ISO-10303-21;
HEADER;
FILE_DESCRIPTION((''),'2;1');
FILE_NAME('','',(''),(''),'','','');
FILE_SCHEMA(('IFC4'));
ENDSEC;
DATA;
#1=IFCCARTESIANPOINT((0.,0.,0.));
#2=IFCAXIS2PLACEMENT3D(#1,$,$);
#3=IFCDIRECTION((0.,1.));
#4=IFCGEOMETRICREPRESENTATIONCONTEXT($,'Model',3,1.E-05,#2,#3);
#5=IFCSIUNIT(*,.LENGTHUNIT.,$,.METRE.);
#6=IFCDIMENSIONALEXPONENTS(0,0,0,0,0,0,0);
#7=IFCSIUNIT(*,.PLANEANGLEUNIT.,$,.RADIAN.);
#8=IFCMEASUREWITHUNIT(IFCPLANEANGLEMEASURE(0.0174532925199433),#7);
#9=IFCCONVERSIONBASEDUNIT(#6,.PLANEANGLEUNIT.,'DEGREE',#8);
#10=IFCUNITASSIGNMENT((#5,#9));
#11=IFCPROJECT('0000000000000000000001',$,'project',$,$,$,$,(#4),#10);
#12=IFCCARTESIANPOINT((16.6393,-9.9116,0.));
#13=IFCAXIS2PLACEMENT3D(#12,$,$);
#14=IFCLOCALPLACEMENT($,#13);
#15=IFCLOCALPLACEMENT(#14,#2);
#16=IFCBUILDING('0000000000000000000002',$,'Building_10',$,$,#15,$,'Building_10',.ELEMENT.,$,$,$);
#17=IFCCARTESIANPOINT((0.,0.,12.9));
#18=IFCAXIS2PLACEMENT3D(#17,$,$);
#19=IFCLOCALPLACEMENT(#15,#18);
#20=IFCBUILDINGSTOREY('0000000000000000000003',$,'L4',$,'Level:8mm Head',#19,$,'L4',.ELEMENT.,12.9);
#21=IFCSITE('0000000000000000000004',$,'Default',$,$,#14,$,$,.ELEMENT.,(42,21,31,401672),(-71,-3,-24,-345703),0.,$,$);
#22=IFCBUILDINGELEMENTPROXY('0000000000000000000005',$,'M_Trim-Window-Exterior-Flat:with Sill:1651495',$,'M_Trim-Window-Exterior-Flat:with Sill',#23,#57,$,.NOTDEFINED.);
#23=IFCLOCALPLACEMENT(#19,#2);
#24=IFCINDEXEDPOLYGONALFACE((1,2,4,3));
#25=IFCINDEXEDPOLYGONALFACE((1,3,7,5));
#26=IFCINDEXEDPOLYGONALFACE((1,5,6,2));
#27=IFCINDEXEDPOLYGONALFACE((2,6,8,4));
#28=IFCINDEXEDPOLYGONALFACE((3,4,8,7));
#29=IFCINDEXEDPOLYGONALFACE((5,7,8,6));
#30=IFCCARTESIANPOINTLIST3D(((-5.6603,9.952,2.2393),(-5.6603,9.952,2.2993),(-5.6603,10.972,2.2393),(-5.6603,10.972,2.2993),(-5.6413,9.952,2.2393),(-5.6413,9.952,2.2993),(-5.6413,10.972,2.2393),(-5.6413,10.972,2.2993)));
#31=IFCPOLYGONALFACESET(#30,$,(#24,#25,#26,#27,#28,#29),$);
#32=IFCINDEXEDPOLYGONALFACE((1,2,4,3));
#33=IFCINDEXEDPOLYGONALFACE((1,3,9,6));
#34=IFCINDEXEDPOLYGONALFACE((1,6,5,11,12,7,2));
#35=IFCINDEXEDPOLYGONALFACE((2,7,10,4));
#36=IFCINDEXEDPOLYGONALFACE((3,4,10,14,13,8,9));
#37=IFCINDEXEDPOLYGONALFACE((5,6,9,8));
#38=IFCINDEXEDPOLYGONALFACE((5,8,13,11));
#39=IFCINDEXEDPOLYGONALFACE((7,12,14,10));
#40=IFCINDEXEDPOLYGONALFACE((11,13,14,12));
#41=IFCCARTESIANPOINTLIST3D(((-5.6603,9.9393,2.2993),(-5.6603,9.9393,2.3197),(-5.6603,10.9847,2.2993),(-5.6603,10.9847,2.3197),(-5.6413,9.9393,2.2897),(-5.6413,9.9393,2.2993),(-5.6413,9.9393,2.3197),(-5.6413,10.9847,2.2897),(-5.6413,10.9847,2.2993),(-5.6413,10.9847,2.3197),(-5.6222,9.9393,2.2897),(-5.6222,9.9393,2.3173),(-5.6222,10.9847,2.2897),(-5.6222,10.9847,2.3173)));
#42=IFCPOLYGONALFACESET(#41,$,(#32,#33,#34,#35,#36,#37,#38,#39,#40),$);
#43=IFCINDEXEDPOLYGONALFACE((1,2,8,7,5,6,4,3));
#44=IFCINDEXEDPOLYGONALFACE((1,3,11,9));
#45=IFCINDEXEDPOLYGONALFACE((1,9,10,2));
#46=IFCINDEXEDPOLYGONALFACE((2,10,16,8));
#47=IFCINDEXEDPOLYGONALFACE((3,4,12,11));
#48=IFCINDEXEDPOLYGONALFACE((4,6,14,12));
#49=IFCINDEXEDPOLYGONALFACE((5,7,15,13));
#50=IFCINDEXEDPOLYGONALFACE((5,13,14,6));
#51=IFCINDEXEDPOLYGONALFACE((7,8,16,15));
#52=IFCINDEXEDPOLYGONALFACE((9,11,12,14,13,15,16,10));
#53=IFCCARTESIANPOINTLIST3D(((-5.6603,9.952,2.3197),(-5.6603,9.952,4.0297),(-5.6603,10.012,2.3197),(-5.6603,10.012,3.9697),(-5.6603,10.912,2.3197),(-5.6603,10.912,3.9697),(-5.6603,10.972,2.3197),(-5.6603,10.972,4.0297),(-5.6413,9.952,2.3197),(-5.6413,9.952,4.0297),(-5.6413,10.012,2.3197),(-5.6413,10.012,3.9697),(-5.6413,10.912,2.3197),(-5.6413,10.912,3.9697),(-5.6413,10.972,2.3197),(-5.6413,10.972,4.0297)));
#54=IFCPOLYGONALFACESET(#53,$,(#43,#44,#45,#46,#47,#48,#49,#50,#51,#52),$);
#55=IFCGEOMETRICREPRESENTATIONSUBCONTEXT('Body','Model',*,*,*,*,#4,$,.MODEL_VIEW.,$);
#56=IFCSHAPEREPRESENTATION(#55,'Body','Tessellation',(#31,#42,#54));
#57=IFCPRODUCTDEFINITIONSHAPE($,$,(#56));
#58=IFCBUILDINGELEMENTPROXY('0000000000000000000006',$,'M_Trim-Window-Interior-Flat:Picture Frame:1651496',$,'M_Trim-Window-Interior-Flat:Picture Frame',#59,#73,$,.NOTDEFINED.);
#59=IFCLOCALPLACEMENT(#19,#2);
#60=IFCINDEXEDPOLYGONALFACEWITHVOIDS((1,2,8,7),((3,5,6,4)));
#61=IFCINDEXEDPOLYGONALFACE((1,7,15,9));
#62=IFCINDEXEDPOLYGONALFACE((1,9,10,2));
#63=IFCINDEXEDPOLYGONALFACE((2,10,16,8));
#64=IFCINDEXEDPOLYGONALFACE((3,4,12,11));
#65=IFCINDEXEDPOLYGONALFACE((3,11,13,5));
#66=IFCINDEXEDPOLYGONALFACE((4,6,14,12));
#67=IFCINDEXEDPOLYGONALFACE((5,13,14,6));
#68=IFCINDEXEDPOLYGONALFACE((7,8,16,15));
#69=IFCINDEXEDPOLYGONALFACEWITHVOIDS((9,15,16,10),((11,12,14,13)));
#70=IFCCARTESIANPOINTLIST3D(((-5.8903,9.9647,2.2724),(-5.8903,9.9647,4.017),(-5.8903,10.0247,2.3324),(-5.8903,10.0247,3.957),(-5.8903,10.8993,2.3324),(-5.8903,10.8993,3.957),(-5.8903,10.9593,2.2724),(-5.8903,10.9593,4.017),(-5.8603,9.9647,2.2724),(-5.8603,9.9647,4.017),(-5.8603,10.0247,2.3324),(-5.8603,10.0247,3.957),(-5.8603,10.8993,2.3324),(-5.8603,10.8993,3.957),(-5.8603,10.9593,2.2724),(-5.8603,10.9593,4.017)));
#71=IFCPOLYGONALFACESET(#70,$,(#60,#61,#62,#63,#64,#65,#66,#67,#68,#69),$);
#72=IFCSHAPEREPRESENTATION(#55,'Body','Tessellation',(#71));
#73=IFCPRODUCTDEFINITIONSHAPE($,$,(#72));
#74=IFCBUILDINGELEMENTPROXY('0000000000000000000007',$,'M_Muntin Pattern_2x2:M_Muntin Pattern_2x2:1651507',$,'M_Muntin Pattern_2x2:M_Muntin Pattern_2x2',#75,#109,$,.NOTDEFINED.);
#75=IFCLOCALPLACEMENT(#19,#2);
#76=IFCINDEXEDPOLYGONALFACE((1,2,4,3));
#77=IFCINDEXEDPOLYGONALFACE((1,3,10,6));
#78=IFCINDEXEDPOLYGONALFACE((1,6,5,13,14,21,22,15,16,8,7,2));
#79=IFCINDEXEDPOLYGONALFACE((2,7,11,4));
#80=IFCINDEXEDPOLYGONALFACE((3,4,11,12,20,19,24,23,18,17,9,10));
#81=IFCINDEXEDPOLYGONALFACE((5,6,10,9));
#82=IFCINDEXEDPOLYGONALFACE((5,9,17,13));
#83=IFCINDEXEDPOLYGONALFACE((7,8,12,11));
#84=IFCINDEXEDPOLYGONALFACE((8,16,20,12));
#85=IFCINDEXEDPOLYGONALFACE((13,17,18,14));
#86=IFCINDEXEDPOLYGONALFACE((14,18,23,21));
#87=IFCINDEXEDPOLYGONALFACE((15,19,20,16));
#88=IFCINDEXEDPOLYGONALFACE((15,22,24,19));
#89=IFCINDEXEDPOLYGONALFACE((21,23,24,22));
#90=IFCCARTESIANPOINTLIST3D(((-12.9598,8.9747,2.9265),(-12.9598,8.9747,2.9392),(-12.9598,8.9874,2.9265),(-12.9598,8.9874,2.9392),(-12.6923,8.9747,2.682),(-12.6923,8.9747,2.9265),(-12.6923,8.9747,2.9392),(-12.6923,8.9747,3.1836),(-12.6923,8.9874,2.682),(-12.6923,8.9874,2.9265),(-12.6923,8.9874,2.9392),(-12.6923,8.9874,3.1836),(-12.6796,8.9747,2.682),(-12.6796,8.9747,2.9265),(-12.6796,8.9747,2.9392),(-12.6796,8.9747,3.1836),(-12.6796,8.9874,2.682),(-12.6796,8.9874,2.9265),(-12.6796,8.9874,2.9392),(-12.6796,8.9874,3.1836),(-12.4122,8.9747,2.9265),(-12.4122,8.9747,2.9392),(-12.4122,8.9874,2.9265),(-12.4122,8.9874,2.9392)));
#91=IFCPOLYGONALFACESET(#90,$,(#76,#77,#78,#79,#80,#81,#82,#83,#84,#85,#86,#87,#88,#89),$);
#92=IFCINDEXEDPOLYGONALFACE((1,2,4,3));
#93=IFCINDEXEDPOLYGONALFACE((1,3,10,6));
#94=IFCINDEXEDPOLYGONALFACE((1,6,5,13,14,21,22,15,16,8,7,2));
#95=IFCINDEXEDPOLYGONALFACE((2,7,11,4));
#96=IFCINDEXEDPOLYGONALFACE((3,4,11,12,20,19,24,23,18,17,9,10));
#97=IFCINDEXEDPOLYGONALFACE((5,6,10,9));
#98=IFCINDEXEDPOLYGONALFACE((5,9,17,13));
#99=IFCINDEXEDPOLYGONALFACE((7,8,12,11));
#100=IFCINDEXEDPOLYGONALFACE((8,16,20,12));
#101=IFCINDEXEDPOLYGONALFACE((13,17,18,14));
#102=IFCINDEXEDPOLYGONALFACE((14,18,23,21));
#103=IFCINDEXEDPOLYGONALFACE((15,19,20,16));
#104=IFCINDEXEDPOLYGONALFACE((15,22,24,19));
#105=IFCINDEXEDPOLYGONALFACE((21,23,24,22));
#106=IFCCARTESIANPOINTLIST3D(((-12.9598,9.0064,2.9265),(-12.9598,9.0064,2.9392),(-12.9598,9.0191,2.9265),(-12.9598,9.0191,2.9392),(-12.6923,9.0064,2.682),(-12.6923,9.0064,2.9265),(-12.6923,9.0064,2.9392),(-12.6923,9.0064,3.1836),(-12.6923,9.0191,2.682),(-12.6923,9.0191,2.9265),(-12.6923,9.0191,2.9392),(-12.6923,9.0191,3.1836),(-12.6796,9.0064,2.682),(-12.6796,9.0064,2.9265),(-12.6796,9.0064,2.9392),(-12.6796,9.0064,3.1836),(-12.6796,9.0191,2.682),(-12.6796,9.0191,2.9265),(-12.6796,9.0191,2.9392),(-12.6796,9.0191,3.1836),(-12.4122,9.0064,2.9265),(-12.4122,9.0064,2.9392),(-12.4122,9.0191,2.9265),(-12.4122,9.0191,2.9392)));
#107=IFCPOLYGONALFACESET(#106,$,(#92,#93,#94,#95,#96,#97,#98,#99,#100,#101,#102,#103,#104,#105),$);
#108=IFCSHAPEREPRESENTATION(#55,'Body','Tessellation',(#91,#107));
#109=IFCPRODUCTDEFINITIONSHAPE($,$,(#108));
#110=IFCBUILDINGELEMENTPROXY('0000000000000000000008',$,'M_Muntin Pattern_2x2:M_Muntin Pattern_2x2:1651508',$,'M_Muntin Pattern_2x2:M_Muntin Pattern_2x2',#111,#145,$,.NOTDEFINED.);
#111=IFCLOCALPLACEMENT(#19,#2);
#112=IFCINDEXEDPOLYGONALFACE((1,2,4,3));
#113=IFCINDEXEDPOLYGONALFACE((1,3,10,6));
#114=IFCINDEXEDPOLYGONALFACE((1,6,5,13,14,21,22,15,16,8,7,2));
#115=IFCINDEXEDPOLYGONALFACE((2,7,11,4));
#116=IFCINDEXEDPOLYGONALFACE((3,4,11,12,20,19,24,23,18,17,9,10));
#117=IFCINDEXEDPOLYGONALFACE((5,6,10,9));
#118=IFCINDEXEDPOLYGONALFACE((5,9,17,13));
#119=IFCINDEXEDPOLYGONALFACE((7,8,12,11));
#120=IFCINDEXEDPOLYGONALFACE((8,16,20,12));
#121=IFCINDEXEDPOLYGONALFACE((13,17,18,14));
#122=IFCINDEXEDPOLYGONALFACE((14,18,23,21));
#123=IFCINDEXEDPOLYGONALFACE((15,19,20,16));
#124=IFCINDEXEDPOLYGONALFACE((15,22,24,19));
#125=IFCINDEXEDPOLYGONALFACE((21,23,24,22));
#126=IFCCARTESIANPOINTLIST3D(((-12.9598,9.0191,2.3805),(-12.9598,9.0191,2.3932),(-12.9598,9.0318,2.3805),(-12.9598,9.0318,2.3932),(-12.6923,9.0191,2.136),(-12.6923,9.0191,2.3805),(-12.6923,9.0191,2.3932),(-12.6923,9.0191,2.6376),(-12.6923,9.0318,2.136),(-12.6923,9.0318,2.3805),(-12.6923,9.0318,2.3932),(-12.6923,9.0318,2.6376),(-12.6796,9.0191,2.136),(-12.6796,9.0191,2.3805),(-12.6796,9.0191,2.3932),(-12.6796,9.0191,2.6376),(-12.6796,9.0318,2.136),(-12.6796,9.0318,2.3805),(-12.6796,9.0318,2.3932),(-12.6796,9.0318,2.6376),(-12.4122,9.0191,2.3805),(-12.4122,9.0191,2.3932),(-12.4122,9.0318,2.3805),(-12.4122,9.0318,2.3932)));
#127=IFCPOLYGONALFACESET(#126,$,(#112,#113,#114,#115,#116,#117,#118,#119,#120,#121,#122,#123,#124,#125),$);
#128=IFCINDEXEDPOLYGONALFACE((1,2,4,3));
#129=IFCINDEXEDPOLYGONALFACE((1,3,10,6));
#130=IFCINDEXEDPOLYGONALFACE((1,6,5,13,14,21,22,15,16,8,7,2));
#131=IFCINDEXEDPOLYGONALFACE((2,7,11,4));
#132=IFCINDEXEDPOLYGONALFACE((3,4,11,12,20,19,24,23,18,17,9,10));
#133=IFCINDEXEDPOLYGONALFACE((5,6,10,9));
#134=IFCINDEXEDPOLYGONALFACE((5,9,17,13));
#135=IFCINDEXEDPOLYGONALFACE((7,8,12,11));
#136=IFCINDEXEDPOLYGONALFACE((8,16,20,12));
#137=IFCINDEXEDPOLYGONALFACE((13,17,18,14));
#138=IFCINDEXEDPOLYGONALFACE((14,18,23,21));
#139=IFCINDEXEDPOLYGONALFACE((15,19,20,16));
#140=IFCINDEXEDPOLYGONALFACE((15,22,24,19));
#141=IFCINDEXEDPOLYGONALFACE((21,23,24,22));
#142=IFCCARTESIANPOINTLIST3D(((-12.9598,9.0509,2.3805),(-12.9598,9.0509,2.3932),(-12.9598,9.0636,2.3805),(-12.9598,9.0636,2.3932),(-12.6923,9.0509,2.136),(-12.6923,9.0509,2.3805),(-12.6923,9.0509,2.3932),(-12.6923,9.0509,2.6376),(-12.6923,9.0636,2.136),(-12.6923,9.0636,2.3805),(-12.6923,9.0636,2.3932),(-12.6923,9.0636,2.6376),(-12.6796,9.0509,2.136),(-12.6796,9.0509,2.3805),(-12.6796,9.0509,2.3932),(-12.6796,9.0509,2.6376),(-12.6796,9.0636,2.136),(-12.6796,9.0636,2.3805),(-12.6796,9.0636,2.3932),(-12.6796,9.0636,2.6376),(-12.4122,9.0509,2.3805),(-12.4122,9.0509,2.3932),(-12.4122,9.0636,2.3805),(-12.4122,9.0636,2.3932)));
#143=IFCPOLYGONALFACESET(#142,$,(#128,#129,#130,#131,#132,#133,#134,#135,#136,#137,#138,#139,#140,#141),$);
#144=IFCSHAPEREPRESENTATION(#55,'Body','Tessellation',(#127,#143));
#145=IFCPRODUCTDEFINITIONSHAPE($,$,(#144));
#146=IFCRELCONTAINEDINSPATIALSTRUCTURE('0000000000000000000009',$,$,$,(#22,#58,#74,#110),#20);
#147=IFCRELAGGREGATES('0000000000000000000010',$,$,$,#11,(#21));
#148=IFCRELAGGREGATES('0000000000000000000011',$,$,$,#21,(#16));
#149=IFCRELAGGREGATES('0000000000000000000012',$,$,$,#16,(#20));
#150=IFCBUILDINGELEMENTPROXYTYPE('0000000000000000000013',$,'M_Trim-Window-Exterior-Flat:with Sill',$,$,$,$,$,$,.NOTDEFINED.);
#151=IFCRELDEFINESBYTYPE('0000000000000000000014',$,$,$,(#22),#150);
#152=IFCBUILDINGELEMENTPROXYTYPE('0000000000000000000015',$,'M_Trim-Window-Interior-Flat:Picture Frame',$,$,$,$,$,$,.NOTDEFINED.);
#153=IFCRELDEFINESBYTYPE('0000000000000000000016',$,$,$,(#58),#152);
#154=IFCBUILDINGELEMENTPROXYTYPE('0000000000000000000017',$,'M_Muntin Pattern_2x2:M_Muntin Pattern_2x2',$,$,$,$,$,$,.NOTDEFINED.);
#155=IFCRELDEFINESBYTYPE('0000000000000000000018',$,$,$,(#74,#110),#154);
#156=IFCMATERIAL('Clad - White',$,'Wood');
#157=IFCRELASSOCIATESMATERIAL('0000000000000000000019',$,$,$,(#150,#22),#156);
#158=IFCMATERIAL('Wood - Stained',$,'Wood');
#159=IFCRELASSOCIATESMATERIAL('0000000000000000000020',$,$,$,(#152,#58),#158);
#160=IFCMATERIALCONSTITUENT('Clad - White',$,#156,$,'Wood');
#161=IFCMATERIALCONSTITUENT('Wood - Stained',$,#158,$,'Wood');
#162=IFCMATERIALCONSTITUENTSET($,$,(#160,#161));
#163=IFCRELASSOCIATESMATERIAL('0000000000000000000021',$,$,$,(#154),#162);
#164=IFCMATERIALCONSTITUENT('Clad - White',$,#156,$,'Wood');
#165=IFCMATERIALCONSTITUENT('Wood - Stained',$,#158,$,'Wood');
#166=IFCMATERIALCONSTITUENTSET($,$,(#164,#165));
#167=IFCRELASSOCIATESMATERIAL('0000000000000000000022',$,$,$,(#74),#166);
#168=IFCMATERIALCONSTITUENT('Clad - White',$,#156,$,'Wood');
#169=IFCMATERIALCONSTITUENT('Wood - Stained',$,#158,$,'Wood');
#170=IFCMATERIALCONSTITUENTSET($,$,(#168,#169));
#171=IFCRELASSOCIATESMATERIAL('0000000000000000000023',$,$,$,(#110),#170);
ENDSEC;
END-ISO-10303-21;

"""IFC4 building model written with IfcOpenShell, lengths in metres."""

from ifc_helpers import new_model, entity, si_unit, converted_unit, direction, frame, origin, place, context, subcontext, project, spatial, indexed_curve, outline, extrude, source, transform, mapped, material, constituent, constituent_set, type_object, type_shapes, element, save


model = new_model("IFC4")

# Units and contexts
model_context = context("Model", 3, precision=1e-05, world=origin(), true_north=direction((0.0, 1.0)))
body_context = subcontext(model_context, "Body", "Model", "MODEL_VIEW")
ifc_project = project(units=[si_unit("LENGTHUNIT", "METRE"), converted_unit("PLANEANGLEUNIT", "DEGREE", entity("IfcPlaneAngleMeasure", 0.0174532925199433), si_unit("PLANEANGLEUNIT", "RADIAN"), dimensions=[0, 0, 0, 0, 0, 0, 0])], contexts=[model_context])

# Site, building, storey
site_placement = place(None, frame((16.6393, -9.9116, 0.0)))
site = spatial("IfcSite", under=ifc_project, at=site_placement, Name="Default", CompositionType="ELEMENT", RefLatitude=(42, 21, 31, 401672), RefLongitude=(-71, -3, -24, -345703), RefElevation=0.0)
building_placement = place(site_placement, origin())
building = spatial("IfcBuilding", under=site, at=building_placement, Name="Building_10", LongName="Building_10", CompositionType="ELEMENT")
storey_placement = place(building_placement, frame((0.0, 0.0, 12.9)))
storey = spatial("IfcBuildingStorey", under=building, at=storey_placement, Name="L4", ObjectType="Level:8mm Head", LongName="L4", CompositionType="ELEMENT", Elevation=12.9)

# Building element proxies
ifc_material_1 = material(Name="Clad - White", Category="Wood")
ifc_material_2 = material(Name="Wood - Stained", Category="Wood")
building_element_proxy_type_1 = type_object("IfcBuildingElementProxyType", Name="M_Trim-Window-Exterior-Flat:with Sill", PredefinedType="NOTDEFINED", material=ifc_material_1)
shared_shape_1 = source(origin(), body_context, "Body", "SweptSolid", [
    extrude(outline(indexed_curve([(-0.51, -0.03), (0.51, -0.03), (0.51, 0.03), (-0.51, 0.03), (-0.51, -0.03)], self_intersect=False)), frame((0.0, -1.7004, 0.0), z_axis=(0.0, 0.0, 1.0), x_axis=(-1.0, 0.0, 0.0)), (0.0, 0.0, 1.0), 0.0191),
    extrude(outline(indexed_curve([(-0.019, -0.0152), (0.0, -0.0152), (0.0, -0.0057), (0.019, -0.0057), (0.019, 0.0148), (0.0, 0.0148), (-0.019, 0.0123), (-0.019, -0.0152)], self_intersect=False)), frame((-0.5227, -1.6648, 0.019), z_axis=(1.0, 0.0, 0.0), x_axis=(0.0, 0.0, -1.0)), (0.0, 0.0, 1.0), 1.0454),
    extrude(outline(indexed_curve([(-0.87, -0.51), (0.84, -0.51), (0.84, -0.45), (-0.81, -0.45), (-0.81, 0.45), (0.84, 0.45), (0.84, 0.51), (-0.87, 0.51), (-0.87, -0.51)], self_intersect=False)), frame((0.0, -0.81, 0.0), z_axis=(0.0, 0.0, 1.0), x_axis=(0.0, -1.0, 0.0)), (0.0, 0.0, 1.0), 0.0191),
])
type_shapes(building_element_proxy_type_1, [shared_shape_1])
proxy_1_placement = place(storey_placement, frame((-5.6603, 10.462, 3.9697), z_axis=(1.0, 0.0, 0.0), x_axis=(0.0, 1.0, 0.0)))
element("IfcBuildingElementProxy", 1, at=proxy_1_placement, inside=storey, type_object=building_element_proxy_type_1, material=ifc_material_1, Name="M_Trim-Window-Exterior-Flat:with Sill:1651495", ObjectType="M_Trim-Window-Exterior-Flat:with Sill", PredefinedType="NOTDEFINED", context=body_context, shape_type="MappedRepresentation", body=[
    mapped(shared_shape_1, transform((0.0, 0.0, 0.0), scale=1.0)),
])
building_element_proxy_type_2 = type_object("IfcBuildingElementProxyType", Name="M_Trim-Window-Interior-Flat:Picture Frame", PredefinedType="NOTDEFINED", material=ifc_material_2)
shared_shape_2 = source(origin(), body_context, "Body", "SweptSolid", [
    extrude(outline(indexed_curve([(-0.4973, -0.8723), (0.4973, -0.8723), (0.4973, 0.8723), (-0.4973, 0.8723), (-0.4973, -0.8723)], self_intersect=False), holes=[indexed_curve([(-0.4373, -0.8123), (-0.4373, 0.8123), (0.4373, 0.8123), (0.4373, -0.8123), (-0.4373, -0.8123)], self_intersect=False)]), frame((0.0, -0.825, 0.0), z_axis=(0.0, 0.0, 1.0), x_axis=(-1.0, 0.0, 0.0)), (0.0, 0.0, 1.0), 0.03),
])
type_shapes(building_element_proxy_type_2, [shared_shape_2])
proxy_2_placement = place(storey_placement, frame((-5.8603, 10.462, 3.9697), z_axis=(-1.0, 0.0, 0.0), x_axis=(0.0, -1.0, 0.0)))
element("IfcBuildingElementProxy", 2, at=proxy_2_placement, inside=storey, type_object=building_element_proxy_type_2, material=ifc_material_2, Name="M_Trim-Window-Interior-Flat:Picture Frame:1651496", ObjectType="M_Trim-Window-Interior-Flat:Picture Frame", PredefinedType="NOTDEFINED", context=body_context, shape_type="MappedRepresentation", body=[
    mapped(shared_shape_2, transform((0.0, 0.0, 0.0), scale=1.0)),
])
ifc_constituent_1 = constituent(ifc_material_1, Name="Clad - White", Category="Wood")
ifc_constituent_2 = constituent(ifc_material_2, Name="Wood - Stained", Category="Wood")
ifc_constituent_set_1 = constituent_set(constituents=[ifc_constituent_1, ifc_constituent_2])
ifc_constituent_3 = constituent(ifc_material_1, Name="Clad - White", Category="Wood")
ifc_constituent_4 = constituent(ifc_material_2, Name="Wood - Stained", Category="Wood")
ifc_constituent_set_2 = constituent_set(constituents=[ifc_constituent_3, ifc_constituent_4])
building_element_proxy_type_3 = type_object("IfcBuildingElementProxyType", Name="M_Muntin Pattern_2x2:M_Muntin Pattern_2x2", PredefinedType="NOTDEFINED", material=ifc_constituent_set_2)
shared_shape_3 = source(origin(), body_context, "Body", "SweptSolid", [
    extrude(outline(indexed_curve([(0.0064, -0.0064), (0.2508, -0.0064), (0.2508, 0.0063), (0.0064, 0.0063), (0.0064, 0.2738), (-0.0063, 0.2738), (-0.0063, 0.0063), (-0.2508, 0.0063), (-0.2508, -0.0064), (-0.0063, -0.0064), (-0.0063, -0.2738), (0.0064, -0.2738), (0.0064, -0.0064)], self_intersect=False)), frame((0.0, 0.0095, 0.2508), z_axis=(0.0, 1.0, 0.0), x_axis=(0.0, 0.0, 1.0)), (0.0, 0.0, 1.0), 0.0127),
    extrude(outline(indexed_curve([(0.0064, -0.0064), (0.2508, -0.0064), (0.2508, 0.0063), (0.0064, 0.0063), (0.0064, 0.2738), (-0.0063, 0.2738), (-0.0063, 0.0063), (-0.2508, 0.0063), (-0.2508, -0.0064), (-0.0063, -0.0064), (-0.0063, -0.2738), (0.0064, -0.2738), (0.0064, -0.0064)], self_intersect=False)), frame((0.0, -0.0222, 0.2508), z_axis=(0.0, 1.0, 0.0), x_axis=(0.0, 0.0, 1.0)), (0.0, 0.0, 1.0), 0.0127),
])
type_shapes(building_element_proxy_type_3, [shared_shape_3])
proxy_3_placement = place(storey_placement, frame((-12.686, 8.9969, 2.682), z_axis=(0.0, 0.0, 1.0), x_axis=(-1.0, 0.0, 0.0)))
element("IfcBuildingElementProxy", 3, at=proxy_3_placement, inside=storey, type_object=building_element_proxy_type_3, material=ifc_constituent_set_1, Name="M_Muntin Pattern_2x2:M_Muntin Pattern_2x2:1651507", ObjectType="M_Muntin Pattern_2x2:M_Muntin Pattern_2x2", PredefinedType="NOTDEFINED", context=body_context, shape_type="MappedRepresentation", body=[
    mapped(shared_shape_3, transform((0.0, 0.0, 0.0), scale=1.0)),
])
ifc_constituent_5 = constituent(ifc_material_1, Name="Clad - White", Category="Wood")
ifc_constituent_6 = constituent(ifc_material_2, Name="Wood - Stained", Category="Wood")
ifc_constituent_set_3 = constituent_set(constituents=[ifc_constituent_5, ifc_constituent_6])
proxy_4_placement = place(storey_placement, frame((-12.686, 9.0413, 2.136), z_axis=(0.0, 0.0, 1.0), x_axis=(-1.0, 0.0, 0.0)))
element("IfcBuildingElementProxy", 4, at=proxy_4_placement, inside=storey, type_object=building_element_proxy_type_3, material=ifc_constituent_set_3, Name="M_Muntin Pattern_2x2:M_Muntin Pattern_2x2:1651508", ObjectType="M_Muntin Pattern_2x2:M_Muntin Pattern_2x2", PredefinedType="NOTDEFINED", context=body_context, shape_type="MappedRepresentation", body=[
    mapped(shared_shape_3, transform((0.0, 0.0, 0.0), scale=1.0)),
])

save(model, "model.ifc")
